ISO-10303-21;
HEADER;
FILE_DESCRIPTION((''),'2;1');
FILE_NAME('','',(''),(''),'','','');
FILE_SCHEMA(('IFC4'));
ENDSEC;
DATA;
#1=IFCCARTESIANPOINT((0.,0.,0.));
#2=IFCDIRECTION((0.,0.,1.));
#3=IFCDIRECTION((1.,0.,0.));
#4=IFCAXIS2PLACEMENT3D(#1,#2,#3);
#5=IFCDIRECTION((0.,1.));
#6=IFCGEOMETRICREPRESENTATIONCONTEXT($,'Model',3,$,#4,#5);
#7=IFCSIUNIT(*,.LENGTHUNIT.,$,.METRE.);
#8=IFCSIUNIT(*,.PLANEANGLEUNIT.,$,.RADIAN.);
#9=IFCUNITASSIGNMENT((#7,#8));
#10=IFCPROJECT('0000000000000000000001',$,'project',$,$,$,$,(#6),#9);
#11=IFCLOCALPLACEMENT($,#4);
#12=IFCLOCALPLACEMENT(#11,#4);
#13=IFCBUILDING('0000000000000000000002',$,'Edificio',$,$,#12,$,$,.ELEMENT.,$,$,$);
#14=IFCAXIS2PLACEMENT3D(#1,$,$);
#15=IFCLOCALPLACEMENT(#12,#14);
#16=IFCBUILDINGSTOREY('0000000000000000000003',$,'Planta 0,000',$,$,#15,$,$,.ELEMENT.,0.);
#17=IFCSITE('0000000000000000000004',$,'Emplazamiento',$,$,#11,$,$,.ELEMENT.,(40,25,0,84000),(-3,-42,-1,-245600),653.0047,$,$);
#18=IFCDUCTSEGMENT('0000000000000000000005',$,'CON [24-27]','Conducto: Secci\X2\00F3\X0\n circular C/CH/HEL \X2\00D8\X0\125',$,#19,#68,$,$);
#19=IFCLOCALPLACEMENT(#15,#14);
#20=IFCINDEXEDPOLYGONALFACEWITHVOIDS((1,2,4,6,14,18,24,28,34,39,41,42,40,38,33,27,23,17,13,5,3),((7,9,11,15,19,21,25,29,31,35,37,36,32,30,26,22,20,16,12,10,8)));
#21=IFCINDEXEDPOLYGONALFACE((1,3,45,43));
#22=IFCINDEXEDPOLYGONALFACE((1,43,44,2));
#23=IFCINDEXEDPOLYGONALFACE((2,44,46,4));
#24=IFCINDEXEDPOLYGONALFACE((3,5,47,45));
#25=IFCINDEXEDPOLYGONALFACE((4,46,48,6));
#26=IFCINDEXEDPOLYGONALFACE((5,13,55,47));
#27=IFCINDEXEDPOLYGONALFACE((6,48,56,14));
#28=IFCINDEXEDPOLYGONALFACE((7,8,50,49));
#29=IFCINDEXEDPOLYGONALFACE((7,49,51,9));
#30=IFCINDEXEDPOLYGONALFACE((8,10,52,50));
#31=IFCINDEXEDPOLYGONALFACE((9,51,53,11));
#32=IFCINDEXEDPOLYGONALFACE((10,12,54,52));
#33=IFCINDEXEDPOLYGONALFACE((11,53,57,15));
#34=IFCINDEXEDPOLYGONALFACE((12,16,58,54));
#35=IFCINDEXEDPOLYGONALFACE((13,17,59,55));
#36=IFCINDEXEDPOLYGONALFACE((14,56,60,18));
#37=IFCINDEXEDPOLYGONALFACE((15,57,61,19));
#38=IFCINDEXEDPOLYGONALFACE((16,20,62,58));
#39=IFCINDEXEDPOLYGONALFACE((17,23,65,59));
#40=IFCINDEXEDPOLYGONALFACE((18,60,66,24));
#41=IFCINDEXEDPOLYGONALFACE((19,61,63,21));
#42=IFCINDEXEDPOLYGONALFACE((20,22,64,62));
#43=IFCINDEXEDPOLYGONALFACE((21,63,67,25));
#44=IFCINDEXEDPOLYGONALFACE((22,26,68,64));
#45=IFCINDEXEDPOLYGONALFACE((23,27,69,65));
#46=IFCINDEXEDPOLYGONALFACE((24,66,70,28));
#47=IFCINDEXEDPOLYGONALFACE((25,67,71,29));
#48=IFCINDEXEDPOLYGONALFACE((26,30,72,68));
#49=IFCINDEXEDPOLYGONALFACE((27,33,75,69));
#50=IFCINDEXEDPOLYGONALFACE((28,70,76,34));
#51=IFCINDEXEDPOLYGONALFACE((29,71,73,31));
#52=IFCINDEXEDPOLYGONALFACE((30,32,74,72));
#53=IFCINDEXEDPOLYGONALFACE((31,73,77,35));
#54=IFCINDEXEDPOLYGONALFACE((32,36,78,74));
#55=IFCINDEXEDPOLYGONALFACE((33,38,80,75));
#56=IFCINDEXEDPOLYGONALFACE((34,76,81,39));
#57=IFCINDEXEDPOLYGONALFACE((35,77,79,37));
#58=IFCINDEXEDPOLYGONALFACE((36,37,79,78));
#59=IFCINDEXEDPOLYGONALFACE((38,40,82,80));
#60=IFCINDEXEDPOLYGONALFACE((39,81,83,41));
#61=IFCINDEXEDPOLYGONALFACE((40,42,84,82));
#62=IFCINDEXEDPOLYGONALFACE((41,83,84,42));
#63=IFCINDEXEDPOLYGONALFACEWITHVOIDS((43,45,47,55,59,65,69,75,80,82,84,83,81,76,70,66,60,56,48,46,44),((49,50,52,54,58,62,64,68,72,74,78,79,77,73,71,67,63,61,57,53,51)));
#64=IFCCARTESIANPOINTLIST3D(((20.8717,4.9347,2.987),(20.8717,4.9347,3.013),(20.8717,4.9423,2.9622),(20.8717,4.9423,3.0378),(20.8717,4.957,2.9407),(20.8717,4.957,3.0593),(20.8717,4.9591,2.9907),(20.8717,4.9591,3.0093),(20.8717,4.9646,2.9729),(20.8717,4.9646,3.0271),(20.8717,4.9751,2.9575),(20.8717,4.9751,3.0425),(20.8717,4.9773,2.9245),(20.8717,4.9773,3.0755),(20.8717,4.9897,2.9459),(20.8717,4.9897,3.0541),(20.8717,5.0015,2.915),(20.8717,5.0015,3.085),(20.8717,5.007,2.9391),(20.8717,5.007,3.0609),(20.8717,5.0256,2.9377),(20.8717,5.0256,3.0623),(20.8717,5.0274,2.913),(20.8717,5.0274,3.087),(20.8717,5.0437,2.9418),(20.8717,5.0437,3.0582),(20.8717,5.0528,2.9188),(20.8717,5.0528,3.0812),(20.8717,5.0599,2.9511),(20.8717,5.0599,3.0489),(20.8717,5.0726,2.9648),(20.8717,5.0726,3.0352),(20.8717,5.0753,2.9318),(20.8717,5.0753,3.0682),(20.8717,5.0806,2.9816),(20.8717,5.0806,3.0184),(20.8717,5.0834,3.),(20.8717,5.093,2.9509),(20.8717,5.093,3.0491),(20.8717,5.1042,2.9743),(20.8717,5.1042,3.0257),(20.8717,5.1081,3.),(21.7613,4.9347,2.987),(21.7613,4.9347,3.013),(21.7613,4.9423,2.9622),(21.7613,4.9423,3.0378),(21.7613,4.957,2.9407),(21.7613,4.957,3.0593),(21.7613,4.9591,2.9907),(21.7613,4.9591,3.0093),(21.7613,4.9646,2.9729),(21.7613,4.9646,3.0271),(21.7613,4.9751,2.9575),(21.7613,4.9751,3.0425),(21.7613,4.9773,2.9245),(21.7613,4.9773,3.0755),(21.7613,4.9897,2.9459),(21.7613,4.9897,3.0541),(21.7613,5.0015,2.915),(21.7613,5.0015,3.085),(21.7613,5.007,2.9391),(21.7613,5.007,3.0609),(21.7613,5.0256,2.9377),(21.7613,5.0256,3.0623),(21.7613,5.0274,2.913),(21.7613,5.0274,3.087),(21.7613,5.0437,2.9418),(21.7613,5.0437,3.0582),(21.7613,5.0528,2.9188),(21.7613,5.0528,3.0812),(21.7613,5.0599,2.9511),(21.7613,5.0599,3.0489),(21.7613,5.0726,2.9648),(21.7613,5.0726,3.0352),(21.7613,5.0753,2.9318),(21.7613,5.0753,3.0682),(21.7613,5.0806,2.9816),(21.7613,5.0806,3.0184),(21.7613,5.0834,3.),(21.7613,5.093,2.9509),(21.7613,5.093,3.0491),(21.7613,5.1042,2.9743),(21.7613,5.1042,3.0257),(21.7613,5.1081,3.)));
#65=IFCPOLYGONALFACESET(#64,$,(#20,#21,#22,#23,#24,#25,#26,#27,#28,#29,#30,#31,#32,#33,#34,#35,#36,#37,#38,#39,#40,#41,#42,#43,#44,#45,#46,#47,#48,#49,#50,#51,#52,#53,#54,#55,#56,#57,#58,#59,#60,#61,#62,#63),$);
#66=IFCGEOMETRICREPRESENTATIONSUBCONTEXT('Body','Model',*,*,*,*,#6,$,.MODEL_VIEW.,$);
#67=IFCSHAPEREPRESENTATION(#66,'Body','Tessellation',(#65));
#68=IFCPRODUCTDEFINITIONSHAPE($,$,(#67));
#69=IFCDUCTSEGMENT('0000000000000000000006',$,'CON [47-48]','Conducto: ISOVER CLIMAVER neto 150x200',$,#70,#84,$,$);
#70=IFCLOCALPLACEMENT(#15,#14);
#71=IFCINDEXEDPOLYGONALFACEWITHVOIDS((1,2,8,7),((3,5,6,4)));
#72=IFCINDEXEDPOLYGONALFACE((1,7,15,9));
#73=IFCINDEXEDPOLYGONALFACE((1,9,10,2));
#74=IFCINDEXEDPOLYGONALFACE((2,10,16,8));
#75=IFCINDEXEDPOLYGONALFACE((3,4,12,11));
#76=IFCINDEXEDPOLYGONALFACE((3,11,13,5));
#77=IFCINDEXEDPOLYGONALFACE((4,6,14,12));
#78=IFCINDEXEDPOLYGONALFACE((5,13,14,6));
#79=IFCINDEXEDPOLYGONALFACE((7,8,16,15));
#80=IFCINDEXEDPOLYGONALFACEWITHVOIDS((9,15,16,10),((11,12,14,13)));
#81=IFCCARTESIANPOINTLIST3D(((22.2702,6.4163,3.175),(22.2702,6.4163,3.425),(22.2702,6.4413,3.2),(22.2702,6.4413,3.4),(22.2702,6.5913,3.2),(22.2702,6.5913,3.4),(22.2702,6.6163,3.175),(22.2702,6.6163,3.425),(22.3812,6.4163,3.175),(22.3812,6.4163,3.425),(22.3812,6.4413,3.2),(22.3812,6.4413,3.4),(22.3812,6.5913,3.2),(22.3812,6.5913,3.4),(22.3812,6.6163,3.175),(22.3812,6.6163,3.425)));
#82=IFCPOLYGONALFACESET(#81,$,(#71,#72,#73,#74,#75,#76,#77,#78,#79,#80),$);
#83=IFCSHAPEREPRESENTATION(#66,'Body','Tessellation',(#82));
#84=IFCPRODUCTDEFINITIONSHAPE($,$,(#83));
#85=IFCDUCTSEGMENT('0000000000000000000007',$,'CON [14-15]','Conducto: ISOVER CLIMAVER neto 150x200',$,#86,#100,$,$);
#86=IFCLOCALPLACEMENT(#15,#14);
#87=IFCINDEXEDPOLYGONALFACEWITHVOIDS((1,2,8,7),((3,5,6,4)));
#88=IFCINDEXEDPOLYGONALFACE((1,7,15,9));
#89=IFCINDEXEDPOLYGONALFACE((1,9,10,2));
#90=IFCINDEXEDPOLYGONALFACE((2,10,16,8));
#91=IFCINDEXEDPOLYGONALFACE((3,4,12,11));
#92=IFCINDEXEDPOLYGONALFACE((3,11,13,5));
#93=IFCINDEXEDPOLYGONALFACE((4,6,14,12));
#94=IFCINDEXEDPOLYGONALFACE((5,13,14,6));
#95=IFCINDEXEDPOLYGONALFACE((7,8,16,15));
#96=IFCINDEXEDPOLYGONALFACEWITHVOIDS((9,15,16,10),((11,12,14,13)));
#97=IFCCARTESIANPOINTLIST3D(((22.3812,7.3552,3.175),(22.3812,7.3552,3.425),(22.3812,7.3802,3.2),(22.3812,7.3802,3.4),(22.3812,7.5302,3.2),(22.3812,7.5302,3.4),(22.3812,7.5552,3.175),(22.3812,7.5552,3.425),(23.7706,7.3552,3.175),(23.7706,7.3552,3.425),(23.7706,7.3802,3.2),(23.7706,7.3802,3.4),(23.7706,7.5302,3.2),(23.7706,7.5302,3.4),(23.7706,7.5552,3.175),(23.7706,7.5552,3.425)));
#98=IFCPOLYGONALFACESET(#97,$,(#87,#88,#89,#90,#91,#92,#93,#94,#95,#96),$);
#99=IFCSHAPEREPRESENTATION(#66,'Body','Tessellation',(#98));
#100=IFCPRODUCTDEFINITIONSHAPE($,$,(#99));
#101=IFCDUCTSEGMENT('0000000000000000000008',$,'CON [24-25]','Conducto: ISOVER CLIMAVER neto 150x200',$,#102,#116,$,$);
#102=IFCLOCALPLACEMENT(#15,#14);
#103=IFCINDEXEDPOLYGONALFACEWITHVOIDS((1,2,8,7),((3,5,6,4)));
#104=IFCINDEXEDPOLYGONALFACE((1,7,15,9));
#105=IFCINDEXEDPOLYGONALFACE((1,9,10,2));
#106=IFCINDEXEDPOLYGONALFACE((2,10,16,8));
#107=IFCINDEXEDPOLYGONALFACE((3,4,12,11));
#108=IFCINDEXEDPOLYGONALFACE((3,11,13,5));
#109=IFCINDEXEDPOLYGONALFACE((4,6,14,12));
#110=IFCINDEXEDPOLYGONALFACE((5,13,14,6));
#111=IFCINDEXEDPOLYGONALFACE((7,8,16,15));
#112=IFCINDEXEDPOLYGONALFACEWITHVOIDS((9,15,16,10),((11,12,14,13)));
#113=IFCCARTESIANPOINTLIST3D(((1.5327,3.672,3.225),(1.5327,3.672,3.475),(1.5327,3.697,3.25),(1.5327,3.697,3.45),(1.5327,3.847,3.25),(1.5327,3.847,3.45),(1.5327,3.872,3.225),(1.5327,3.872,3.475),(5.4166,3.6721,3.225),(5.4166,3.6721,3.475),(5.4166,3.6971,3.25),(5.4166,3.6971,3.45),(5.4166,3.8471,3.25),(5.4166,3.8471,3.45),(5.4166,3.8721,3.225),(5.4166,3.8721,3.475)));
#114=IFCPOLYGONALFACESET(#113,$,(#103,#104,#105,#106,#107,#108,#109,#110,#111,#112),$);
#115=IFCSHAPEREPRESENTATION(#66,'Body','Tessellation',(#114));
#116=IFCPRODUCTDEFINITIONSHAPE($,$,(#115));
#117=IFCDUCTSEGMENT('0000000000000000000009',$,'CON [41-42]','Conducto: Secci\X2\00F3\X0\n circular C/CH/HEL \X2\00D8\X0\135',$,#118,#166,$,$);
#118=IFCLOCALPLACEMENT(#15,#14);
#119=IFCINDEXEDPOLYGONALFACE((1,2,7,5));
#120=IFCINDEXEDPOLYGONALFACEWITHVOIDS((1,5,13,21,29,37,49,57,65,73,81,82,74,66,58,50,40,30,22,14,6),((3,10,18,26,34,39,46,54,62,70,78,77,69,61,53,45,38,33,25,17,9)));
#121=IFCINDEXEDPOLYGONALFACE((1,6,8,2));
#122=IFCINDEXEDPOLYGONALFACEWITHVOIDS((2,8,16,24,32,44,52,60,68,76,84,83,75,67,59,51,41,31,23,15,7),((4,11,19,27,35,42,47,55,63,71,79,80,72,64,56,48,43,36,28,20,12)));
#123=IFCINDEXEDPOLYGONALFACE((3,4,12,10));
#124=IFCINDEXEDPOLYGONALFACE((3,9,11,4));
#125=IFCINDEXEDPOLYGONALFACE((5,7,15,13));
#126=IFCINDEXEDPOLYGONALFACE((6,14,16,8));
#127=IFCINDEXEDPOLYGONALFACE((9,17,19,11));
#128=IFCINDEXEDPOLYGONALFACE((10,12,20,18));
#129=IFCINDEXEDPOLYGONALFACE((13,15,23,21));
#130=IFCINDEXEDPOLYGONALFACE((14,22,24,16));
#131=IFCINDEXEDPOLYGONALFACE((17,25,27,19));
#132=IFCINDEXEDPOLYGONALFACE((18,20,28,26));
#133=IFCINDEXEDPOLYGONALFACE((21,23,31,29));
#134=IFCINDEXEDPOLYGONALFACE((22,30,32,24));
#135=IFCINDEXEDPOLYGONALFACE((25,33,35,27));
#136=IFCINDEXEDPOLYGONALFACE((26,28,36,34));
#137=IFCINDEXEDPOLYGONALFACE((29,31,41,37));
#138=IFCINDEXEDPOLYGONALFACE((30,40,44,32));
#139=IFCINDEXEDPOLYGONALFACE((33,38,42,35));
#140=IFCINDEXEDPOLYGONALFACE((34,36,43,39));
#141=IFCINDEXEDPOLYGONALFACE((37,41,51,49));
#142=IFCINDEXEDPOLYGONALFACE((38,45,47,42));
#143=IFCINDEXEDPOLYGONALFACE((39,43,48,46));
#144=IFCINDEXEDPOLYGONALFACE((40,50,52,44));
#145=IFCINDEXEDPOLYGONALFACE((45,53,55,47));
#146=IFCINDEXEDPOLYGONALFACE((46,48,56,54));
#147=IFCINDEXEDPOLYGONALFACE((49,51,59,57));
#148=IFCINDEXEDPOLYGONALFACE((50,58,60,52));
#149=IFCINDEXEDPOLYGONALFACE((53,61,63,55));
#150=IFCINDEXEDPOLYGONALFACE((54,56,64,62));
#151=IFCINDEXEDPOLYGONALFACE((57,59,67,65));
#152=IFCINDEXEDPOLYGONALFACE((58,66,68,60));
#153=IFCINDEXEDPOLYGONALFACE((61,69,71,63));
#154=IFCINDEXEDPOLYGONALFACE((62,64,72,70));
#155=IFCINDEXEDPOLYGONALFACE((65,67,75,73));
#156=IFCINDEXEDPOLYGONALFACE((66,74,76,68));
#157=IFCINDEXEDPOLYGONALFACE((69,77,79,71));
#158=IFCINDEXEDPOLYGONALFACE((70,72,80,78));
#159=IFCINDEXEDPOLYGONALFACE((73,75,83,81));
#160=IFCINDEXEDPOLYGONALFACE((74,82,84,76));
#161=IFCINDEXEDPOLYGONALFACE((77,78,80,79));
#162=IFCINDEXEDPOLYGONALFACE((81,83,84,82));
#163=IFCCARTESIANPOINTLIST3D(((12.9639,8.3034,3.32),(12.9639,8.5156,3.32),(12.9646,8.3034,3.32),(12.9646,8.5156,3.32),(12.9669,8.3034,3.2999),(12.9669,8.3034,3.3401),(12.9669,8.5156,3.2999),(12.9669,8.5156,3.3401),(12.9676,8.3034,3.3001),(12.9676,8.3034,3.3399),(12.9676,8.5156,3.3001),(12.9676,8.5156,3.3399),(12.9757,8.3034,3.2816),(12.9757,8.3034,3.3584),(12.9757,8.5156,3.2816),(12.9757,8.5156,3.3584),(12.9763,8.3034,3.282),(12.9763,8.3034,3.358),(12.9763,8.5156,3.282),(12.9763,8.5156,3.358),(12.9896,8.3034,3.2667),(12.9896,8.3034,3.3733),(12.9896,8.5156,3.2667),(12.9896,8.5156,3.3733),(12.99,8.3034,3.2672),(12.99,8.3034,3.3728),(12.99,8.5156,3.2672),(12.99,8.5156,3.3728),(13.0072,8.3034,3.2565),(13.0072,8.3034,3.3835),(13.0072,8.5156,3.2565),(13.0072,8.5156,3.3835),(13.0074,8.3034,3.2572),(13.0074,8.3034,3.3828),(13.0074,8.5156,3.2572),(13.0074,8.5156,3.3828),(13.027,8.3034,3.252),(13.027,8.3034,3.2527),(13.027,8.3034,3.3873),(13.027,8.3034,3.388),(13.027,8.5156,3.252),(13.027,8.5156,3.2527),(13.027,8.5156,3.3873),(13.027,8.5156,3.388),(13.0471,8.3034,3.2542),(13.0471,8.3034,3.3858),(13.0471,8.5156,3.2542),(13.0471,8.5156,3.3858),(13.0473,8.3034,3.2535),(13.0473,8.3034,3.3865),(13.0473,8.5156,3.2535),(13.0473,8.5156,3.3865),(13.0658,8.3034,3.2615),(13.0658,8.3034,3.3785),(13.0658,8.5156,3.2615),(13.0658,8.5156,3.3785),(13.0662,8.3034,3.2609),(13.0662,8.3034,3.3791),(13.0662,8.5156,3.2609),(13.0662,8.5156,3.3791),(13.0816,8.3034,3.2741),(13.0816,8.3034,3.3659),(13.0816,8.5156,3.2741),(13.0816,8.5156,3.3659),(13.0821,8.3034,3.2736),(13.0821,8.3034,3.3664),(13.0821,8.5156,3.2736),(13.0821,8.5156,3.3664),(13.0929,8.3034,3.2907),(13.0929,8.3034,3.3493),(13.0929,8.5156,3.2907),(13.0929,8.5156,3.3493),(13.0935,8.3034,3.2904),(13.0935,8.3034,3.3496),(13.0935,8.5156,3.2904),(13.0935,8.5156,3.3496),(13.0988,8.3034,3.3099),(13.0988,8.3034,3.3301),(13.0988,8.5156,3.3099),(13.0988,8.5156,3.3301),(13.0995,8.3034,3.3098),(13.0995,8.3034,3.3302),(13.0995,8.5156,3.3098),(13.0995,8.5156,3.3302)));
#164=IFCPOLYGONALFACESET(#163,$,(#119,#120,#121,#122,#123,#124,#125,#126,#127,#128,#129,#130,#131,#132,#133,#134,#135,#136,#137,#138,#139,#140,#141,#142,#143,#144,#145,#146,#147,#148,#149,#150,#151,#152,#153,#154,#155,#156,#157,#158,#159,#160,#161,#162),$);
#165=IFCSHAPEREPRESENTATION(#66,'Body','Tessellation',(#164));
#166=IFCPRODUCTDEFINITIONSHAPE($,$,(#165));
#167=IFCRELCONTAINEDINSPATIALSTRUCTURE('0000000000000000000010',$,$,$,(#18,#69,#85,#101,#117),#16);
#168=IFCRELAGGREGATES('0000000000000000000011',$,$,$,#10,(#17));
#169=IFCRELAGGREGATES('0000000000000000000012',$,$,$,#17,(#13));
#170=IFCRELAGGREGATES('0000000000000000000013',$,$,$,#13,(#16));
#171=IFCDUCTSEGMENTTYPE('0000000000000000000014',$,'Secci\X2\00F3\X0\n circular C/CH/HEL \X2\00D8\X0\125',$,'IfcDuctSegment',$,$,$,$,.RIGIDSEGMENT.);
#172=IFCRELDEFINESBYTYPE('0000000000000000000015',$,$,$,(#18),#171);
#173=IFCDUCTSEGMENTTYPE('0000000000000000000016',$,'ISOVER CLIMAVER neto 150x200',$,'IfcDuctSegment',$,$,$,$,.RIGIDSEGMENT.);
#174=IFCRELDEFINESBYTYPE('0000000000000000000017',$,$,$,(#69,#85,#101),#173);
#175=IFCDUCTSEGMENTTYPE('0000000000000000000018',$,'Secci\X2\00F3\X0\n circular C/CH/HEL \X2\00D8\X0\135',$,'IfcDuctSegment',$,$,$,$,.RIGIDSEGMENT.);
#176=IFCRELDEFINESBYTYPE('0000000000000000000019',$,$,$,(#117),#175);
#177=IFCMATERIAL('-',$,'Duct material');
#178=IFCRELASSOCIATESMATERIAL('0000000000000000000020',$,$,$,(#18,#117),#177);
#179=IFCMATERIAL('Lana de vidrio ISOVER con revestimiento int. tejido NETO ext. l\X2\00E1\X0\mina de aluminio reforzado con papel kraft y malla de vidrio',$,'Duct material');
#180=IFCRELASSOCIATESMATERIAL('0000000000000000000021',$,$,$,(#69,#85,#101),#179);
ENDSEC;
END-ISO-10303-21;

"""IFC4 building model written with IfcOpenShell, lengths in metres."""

from ifc_helpers import new_model, si_unit, direction, frame, origin, origin_with_axes, origin_2d_with_axis, place, context, subcontext, project, spatial, hollow_rectangle, hollow_circle, extrude, material, type_object, element, save


model = new_model("IFC4")

# Units and contexts
model_context = context("Model", 3, world=origin_with_axes(), true_north=direction((0.0, 1.0)))
body_context = subcontext(model_context, "Body", "Model", "MODEL_VIEW")
ifc_project = project(units=[si_unit("LENGTHUNIT", "METRE"), si_unit("PLANEANGLEUNIT", "RADIAN")], contexts=[model_context])

# Site, building, storey
site_placement = place(None, origin_with_axes())
site = spatial("IfcSite", under=ifc_project, at=site_placement, Name="Emplazamiento", CompositionType="ELEMENT", RefLatitude=(40, 25, 0, 84000), RefLongitude=(-3, -42, -1, -245600), RefElevation=653.0047)
building_placement = place(site_placement, origin_with_axes())
building = spatial("IfcBuilding", under=site, at=building_placement, Name="Edificio", CompositionType="ELEMENT")
storey_placement = place(building_placement, origin())
storey = spatial("IfcBuildingStorey", under=building, at=storey_placement, Name="Planta 0,000", CompositionType="ELEMENT", Elevation=0.0)

# Duct segment
ifc_material_1 = material(Name="Lana de vidrio ISOVER con revestimiento int. tejido NETO ext. lámina de aluminio reforzado con papel kraft y malla de vidrio", Category="Duct material")
ifc_material_2 = material(Name="-", Category="Duct material")
duct_segment_type_1 = type_object("IfcDuctSegmentType", Name="Sección circular C/CH/HEL Ø125", ApplicableOccurrence="IfcDuctSegment", PredefinedType="RIGIDSEGMENT")
duct_segment_1_placement = place(storey_placement, origin_with_axes())
element("IfcDuctSegment", 1, at=duct_segment_1_placement, inside=storey, type_object=duct_segment_type_1, material=ifc_material_2, Name="CON [24-27]", Description="Conducto: Sección circular C/CH/HEL Ø125", context=body_context, shape_type="SweptSolid", body=[
    extrude(hollow_circle(Radius=0.0872, WallThickness=0.0247, at=origin_2d_with_axis()), frame((20.8717, 5.0209, 3.0), z_axis=(1.0, 0.0, 0.0), x_axis=(0.0, 1.0, 0.0)), (0.0, 0.0, 1.0), 0.8897),
])

# Duct segments
duct_segment_type_2 = type_object("IfcDuctSegmentType", Name="ISOVER CLIMAVER neto 150x200", ApplicableOccurrence="IfcDuctSegment", PredefinedType="RIGIDSEGMENT")
duct_segment_2_placement = place(storey_placement, origin_with_axes())
element("IfcDuctSegment", 2, at=duct_segment_2_placement, inside=storey, type_object=duct_segment_type_2, material=ifc_material_1, Name="CON [47-48]", Description="Conducto: ISOVER CLIMAVER neto 150x200", context=body_context, shape_type="SweptSolid", body=[
    extrude(hollow_rectangle(XDim=0.2, YDim=0.25, WallThickness=0.025, at=origin_2d_with_axis()), frame((22.2702, 6.5163, 3.3), z_axis=(1.0, 0.0, 0.0), x_axis=(0.0, 1.0, 0.0)), (0.0, 0.0, 1.0), 0.111),
])
duct_segment_3_placement = place(storey_placement, origin_with_axes())
element("IfcDuctSegment", 3, at=duct_segment_3_placement, inside=storey, type_object=duct_segment_type_2, material=ifc_material_1, Name="CON [14-15]", Description="Conducto: ISOVER CLIMAVER neto 150x200", context=body_context, shape_type="SweptSolid", body=[
    extrude(hollow_rectangle(XDim=0.2, YDim=0.25, WallThickness=0.025, at=origin_2d_with_axis()), frame((23.7706, 7.4552, 3.3), z_axis=(-1.0, 0.0, 0.0), x_axis=(0.0, -1.0, 0.0)), (0.0, 0.0, 1.0), 1.3894),
])
duct_segment_4_placement = place(storey_placement, origin_with_axes())
element("IfcDuctSegment", 4, at=duct_segment_4_placement, inside=storey, type_object=duct_segment_type_2, material=ifc_material_1, Name="CON [24-25]", Description="Conducto: ISOVER CLIMAVER neto 150x200", context=body_context, shape_type="SweptSolid", body=[
    extrude(hollow_rectangle(XDim=0.2, YDim=0.25, WallThickness=0.025, at=origin_2d_with_axis()), frame((5.4166, 3.7721, 3.35), z_axis=(-1.0, -0.000037, 0.0), x_axis=(0.000037, -1.0, 0.0)), (0.0, 0.0, 1.0), 3.884),
])
duct_segment_type_3 = type_object("IfcDuctSegmentType", Name="Sección circular C/CH/HEL Ø135", ApplicableOccurrence="IfcDuctSegment", PredefinedType="RIGIDSEGMENT")
duct_segment_5_placement = place(storey_placement, origin_with_axes())
element("IfcDuctSegment", 5, at=duct_segment_5_placement, inside=storey, type_object=duct_segment_type_3, material=ifc_material_2, Name="CON [41-42]", Description="Conducto: Sección circular C/CH/HEL Ø135", context=body_context, shape_type="SweptSolid", body=[
    extrude(hollow_circle(Radius=0.0682, WallThickness=0.0007, at=origin_2d_with_axis()), frame((13.0321, 8.3034, 3.32), z_axis=(0.0, 1.0, 0.0), x_axis=(-1.0, 0.0, 0.0)), (0.0, 0.0, 1.0), 0.2122),
])

save(model, "model.ifc")
